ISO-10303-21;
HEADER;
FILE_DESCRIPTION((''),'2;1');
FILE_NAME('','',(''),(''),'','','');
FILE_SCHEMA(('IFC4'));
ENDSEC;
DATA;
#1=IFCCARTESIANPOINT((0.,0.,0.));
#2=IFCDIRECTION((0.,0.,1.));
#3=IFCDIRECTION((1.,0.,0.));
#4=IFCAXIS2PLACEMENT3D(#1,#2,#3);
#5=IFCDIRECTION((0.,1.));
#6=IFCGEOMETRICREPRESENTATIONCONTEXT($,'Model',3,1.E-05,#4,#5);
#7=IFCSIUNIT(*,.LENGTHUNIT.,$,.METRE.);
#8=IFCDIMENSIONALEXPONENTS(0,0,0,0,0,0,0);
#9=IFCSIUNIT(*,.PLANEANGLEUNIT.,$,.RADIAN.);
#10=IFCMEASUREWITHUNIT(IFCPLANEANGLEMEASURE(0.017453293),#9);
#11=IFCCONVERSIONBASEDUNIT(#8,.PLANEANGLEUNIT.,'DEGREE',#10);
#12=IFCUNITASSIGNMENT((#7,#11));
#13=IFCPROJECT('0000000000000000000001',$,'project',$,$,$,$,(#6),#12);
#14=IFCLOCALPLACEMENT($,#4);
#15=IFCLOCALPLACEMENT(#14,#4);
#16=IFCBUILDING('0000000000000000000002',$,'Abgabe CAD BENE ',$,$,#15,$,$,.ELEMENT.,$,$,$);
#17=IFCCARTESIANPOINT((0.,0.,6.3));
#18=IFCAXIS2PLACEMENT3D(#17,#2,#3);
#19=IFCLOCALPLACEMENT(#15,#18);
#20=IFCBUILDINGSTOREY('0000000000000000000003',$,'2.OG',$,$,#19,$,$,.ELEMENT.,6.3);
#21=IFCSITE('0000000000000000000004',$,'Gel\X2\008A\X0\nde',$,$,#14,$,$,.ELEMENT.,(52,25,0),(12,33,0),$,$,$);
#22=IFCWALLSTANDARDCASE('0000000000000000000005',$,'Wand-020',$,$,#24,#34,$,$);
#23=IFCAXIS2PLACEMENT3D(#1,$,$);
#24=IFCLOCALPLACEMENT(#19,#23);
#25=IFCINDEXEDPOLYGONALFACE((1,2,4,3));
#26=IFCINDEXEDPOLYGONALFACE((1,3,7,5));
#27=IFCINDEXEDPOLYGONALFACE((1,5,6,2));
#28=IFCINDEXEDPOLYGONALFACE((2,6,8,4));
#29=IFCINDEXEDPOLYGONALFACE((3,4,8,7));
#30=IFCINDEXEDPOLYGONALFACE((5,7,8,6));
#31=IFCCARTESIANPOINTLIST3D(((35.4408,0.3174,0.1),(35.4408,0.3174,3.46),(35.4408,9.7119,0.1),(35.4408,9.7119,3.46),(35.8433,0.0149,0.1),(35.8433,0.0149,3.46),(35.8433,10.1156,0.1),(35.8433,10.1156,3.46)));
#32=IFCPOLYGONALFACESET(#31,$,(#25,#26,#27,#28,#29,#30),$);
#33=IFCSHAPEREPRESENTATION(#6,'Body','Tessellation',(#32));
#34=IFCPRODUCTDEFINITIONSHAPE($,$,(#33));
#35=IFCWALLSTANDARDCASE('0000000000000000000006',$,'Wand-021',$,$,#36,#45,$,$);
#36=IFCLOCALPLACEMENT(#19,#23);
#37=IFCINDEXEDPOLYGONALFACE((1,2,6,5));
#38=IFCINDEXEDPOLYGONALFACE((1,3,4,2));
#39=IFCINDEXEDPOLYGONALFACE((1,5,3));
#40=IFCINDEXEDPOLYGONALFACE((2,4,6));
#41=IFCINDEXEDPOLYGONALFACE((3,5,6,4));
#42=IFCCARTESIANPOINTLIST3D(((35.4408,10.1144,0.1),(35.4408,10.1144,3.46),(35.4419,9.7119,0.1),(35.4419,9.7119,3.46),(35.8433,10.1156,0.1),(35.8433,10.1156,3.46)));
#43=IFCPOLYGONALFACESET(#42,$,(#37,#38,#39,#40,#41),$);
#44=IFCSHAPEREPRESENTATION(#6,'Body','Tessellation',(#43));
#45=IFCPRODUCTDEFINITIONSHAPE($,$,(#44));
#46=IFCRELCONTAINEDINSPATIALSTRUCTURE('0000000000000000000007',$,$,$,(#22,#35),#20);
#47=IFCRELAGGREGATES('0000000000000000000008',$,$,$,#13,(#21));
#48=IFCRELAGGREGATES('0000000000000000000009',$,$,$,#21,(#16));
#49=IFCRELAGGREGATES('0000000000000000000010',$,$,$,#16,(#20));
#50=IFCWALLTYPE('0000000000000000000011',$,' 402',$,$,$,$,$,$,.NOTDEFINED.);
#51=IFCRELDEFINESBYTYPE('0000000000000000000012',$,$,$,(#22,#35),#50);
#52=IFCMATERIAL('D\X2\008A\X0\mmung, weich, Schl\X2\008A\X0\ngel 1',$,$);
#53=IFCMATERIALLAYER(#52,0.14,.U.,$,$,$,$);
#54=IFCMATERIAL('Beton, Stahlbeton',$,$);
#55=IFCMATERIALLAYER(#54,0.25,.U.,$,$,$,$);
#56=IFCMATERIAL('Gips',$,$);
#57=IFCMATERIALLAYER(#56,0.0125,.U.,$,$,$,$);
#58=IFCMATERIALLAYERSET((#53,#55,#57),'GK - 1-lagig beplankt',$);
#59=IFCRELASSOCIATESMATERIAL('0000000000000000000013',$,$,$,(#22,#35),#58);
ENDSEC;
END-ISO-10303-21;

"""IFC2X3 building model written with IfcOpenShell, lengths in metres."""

from ifc_helpers import new_model, entity, si_unit, converted_unit, direction, frame, origin_with_axes, place, context, project, spatial, polyline, outline, extrude, material, layer, layer_set, layer_usage, type_object, element, save


model = new_model("IFC2X3")

# Units and contexts
model_context = context("Model", 3, precision=1e-05, world=origin_with_axes(), true_north=direction((0.0, 1.0)))
ifc_project = project(units=[si_unit("LENGTHUNIT", "METRE"), converted_unit("PLANEANGLEUNIT", "DEGREE", entity("IfcPlaneAngleMeasure", 0.017453293), si_unit("PLANEANGLEUNIT", "RADIAN"), dimensions=[0, 0, 0, 0, 0, 0, 0])], contexts=[model_context])

# Site, building, storey
site_placement = place(None, origin_with_axes())
site = spatial("IfcSite", under=ifc_project, at=site_placement, Name="Gel\u008ande", CompositionType="ELEMENT", RefLatitude=(52, 25, 0), RefLongitude=(12, 33, 0))
building_placement = place(site_placement, origin_with_axes())
building = spatial("IfcBuilding", under=site, at=building_placement, Name="Abgabe CAD BENE ", CompositionType="ELEMENT")
storey_placement = place(building_placement, frame((0.0, 0.0, 6.3), z_axis=(0.0, 0.0, 1.0), x_axis=(1.0, 0.0, 0.0)))
storey = spatial("IfcBuildingStorey", under=building, at=storey_placement, Name="2.OG", CompositionType="ELEMENT", Elevation=6.3)

# Shared definitions
ifc_material_1 = material(Name="Gips")
ifc_material_2 = material(Name="D\u008ammung, weich, Schl\u008angel 1")
ifc_material_3 = material(Name="Beton, Stahlbeton")

# Walls
ifc_layer_1 = layer(ifc_material_2, 0.14, ventilated="UNKNOWN")
ifc_layer_2 = layer(ifc_material_3, 0.25, ventilated="UNKNOWN")
ifc_layer_3 = layer(ifc_material_1, 0.0125, ventilated="UNKNOWN")
ifc_layer_set_1 = layer_set([ifc_layer_1, ifc_layer_2, ifc_layer_3], Name="GK - 1-lagig beplankt")
ifc_layer_usage_1 = layer_usage(ifc_layer_set_1, "AXIS2", "NEGATIVE", 0.0)
wall_type_1 = type_object("IfcWallType", Name=" 402", PredefinedType="NOTDEFINED")
wall_1_placement = place(storey_placement, frame((35.8433, 10.1156, 0.1), z_axis=(0.0, 0.0, 1.0), x_axis=(0.0, -1.0, 0.0)))
element("IfcWallStandardCase", 1, at=wall_1_placement, inside=storey, type_object=wall_type_1, material=ifc_layer_usage_1, Name="Wand-020", context=model_context, shape_type="SweptSolid", body=[
    extrude(outline(polyline([(0.4037, -0.4025), (9.7982, -0.4025), (10.1007, 0.0), (0.0, 0.0), (0.4037, -0.4025)])), origin_with_axes(), (0.0, 0.0, 1.0), 3.36),
])
ifc_layer_usage_2 = layer_usage(ifc_layer_set_1, "AXIS2", "NEGATIVE", 0.0)
wall_2_placement = place(storey_placement, frame((35.4408, 10.1144, 0.1), z_axis=(0.0, 0.0, 1.0), x_axis=(0.999996, 0.002925, 0.0)))
element("IfcWallStandardCase", 2, at=wall_2_placement, inside=storey, type_object=wall_type_1, material=ifc_layer_usage_2, Name="Wand-021", context=model_context, shape_type="SweptSolid", body=[
    extrude(outline(polyline([(0.0, -0.4025), (0.4025, 0.0), (0.0, 0.0), (0.0, -0.4025)])), origin_with_axes(), (0.0, 0.0, 1.0), 3.36),
])

save(model, "model.ifc")
